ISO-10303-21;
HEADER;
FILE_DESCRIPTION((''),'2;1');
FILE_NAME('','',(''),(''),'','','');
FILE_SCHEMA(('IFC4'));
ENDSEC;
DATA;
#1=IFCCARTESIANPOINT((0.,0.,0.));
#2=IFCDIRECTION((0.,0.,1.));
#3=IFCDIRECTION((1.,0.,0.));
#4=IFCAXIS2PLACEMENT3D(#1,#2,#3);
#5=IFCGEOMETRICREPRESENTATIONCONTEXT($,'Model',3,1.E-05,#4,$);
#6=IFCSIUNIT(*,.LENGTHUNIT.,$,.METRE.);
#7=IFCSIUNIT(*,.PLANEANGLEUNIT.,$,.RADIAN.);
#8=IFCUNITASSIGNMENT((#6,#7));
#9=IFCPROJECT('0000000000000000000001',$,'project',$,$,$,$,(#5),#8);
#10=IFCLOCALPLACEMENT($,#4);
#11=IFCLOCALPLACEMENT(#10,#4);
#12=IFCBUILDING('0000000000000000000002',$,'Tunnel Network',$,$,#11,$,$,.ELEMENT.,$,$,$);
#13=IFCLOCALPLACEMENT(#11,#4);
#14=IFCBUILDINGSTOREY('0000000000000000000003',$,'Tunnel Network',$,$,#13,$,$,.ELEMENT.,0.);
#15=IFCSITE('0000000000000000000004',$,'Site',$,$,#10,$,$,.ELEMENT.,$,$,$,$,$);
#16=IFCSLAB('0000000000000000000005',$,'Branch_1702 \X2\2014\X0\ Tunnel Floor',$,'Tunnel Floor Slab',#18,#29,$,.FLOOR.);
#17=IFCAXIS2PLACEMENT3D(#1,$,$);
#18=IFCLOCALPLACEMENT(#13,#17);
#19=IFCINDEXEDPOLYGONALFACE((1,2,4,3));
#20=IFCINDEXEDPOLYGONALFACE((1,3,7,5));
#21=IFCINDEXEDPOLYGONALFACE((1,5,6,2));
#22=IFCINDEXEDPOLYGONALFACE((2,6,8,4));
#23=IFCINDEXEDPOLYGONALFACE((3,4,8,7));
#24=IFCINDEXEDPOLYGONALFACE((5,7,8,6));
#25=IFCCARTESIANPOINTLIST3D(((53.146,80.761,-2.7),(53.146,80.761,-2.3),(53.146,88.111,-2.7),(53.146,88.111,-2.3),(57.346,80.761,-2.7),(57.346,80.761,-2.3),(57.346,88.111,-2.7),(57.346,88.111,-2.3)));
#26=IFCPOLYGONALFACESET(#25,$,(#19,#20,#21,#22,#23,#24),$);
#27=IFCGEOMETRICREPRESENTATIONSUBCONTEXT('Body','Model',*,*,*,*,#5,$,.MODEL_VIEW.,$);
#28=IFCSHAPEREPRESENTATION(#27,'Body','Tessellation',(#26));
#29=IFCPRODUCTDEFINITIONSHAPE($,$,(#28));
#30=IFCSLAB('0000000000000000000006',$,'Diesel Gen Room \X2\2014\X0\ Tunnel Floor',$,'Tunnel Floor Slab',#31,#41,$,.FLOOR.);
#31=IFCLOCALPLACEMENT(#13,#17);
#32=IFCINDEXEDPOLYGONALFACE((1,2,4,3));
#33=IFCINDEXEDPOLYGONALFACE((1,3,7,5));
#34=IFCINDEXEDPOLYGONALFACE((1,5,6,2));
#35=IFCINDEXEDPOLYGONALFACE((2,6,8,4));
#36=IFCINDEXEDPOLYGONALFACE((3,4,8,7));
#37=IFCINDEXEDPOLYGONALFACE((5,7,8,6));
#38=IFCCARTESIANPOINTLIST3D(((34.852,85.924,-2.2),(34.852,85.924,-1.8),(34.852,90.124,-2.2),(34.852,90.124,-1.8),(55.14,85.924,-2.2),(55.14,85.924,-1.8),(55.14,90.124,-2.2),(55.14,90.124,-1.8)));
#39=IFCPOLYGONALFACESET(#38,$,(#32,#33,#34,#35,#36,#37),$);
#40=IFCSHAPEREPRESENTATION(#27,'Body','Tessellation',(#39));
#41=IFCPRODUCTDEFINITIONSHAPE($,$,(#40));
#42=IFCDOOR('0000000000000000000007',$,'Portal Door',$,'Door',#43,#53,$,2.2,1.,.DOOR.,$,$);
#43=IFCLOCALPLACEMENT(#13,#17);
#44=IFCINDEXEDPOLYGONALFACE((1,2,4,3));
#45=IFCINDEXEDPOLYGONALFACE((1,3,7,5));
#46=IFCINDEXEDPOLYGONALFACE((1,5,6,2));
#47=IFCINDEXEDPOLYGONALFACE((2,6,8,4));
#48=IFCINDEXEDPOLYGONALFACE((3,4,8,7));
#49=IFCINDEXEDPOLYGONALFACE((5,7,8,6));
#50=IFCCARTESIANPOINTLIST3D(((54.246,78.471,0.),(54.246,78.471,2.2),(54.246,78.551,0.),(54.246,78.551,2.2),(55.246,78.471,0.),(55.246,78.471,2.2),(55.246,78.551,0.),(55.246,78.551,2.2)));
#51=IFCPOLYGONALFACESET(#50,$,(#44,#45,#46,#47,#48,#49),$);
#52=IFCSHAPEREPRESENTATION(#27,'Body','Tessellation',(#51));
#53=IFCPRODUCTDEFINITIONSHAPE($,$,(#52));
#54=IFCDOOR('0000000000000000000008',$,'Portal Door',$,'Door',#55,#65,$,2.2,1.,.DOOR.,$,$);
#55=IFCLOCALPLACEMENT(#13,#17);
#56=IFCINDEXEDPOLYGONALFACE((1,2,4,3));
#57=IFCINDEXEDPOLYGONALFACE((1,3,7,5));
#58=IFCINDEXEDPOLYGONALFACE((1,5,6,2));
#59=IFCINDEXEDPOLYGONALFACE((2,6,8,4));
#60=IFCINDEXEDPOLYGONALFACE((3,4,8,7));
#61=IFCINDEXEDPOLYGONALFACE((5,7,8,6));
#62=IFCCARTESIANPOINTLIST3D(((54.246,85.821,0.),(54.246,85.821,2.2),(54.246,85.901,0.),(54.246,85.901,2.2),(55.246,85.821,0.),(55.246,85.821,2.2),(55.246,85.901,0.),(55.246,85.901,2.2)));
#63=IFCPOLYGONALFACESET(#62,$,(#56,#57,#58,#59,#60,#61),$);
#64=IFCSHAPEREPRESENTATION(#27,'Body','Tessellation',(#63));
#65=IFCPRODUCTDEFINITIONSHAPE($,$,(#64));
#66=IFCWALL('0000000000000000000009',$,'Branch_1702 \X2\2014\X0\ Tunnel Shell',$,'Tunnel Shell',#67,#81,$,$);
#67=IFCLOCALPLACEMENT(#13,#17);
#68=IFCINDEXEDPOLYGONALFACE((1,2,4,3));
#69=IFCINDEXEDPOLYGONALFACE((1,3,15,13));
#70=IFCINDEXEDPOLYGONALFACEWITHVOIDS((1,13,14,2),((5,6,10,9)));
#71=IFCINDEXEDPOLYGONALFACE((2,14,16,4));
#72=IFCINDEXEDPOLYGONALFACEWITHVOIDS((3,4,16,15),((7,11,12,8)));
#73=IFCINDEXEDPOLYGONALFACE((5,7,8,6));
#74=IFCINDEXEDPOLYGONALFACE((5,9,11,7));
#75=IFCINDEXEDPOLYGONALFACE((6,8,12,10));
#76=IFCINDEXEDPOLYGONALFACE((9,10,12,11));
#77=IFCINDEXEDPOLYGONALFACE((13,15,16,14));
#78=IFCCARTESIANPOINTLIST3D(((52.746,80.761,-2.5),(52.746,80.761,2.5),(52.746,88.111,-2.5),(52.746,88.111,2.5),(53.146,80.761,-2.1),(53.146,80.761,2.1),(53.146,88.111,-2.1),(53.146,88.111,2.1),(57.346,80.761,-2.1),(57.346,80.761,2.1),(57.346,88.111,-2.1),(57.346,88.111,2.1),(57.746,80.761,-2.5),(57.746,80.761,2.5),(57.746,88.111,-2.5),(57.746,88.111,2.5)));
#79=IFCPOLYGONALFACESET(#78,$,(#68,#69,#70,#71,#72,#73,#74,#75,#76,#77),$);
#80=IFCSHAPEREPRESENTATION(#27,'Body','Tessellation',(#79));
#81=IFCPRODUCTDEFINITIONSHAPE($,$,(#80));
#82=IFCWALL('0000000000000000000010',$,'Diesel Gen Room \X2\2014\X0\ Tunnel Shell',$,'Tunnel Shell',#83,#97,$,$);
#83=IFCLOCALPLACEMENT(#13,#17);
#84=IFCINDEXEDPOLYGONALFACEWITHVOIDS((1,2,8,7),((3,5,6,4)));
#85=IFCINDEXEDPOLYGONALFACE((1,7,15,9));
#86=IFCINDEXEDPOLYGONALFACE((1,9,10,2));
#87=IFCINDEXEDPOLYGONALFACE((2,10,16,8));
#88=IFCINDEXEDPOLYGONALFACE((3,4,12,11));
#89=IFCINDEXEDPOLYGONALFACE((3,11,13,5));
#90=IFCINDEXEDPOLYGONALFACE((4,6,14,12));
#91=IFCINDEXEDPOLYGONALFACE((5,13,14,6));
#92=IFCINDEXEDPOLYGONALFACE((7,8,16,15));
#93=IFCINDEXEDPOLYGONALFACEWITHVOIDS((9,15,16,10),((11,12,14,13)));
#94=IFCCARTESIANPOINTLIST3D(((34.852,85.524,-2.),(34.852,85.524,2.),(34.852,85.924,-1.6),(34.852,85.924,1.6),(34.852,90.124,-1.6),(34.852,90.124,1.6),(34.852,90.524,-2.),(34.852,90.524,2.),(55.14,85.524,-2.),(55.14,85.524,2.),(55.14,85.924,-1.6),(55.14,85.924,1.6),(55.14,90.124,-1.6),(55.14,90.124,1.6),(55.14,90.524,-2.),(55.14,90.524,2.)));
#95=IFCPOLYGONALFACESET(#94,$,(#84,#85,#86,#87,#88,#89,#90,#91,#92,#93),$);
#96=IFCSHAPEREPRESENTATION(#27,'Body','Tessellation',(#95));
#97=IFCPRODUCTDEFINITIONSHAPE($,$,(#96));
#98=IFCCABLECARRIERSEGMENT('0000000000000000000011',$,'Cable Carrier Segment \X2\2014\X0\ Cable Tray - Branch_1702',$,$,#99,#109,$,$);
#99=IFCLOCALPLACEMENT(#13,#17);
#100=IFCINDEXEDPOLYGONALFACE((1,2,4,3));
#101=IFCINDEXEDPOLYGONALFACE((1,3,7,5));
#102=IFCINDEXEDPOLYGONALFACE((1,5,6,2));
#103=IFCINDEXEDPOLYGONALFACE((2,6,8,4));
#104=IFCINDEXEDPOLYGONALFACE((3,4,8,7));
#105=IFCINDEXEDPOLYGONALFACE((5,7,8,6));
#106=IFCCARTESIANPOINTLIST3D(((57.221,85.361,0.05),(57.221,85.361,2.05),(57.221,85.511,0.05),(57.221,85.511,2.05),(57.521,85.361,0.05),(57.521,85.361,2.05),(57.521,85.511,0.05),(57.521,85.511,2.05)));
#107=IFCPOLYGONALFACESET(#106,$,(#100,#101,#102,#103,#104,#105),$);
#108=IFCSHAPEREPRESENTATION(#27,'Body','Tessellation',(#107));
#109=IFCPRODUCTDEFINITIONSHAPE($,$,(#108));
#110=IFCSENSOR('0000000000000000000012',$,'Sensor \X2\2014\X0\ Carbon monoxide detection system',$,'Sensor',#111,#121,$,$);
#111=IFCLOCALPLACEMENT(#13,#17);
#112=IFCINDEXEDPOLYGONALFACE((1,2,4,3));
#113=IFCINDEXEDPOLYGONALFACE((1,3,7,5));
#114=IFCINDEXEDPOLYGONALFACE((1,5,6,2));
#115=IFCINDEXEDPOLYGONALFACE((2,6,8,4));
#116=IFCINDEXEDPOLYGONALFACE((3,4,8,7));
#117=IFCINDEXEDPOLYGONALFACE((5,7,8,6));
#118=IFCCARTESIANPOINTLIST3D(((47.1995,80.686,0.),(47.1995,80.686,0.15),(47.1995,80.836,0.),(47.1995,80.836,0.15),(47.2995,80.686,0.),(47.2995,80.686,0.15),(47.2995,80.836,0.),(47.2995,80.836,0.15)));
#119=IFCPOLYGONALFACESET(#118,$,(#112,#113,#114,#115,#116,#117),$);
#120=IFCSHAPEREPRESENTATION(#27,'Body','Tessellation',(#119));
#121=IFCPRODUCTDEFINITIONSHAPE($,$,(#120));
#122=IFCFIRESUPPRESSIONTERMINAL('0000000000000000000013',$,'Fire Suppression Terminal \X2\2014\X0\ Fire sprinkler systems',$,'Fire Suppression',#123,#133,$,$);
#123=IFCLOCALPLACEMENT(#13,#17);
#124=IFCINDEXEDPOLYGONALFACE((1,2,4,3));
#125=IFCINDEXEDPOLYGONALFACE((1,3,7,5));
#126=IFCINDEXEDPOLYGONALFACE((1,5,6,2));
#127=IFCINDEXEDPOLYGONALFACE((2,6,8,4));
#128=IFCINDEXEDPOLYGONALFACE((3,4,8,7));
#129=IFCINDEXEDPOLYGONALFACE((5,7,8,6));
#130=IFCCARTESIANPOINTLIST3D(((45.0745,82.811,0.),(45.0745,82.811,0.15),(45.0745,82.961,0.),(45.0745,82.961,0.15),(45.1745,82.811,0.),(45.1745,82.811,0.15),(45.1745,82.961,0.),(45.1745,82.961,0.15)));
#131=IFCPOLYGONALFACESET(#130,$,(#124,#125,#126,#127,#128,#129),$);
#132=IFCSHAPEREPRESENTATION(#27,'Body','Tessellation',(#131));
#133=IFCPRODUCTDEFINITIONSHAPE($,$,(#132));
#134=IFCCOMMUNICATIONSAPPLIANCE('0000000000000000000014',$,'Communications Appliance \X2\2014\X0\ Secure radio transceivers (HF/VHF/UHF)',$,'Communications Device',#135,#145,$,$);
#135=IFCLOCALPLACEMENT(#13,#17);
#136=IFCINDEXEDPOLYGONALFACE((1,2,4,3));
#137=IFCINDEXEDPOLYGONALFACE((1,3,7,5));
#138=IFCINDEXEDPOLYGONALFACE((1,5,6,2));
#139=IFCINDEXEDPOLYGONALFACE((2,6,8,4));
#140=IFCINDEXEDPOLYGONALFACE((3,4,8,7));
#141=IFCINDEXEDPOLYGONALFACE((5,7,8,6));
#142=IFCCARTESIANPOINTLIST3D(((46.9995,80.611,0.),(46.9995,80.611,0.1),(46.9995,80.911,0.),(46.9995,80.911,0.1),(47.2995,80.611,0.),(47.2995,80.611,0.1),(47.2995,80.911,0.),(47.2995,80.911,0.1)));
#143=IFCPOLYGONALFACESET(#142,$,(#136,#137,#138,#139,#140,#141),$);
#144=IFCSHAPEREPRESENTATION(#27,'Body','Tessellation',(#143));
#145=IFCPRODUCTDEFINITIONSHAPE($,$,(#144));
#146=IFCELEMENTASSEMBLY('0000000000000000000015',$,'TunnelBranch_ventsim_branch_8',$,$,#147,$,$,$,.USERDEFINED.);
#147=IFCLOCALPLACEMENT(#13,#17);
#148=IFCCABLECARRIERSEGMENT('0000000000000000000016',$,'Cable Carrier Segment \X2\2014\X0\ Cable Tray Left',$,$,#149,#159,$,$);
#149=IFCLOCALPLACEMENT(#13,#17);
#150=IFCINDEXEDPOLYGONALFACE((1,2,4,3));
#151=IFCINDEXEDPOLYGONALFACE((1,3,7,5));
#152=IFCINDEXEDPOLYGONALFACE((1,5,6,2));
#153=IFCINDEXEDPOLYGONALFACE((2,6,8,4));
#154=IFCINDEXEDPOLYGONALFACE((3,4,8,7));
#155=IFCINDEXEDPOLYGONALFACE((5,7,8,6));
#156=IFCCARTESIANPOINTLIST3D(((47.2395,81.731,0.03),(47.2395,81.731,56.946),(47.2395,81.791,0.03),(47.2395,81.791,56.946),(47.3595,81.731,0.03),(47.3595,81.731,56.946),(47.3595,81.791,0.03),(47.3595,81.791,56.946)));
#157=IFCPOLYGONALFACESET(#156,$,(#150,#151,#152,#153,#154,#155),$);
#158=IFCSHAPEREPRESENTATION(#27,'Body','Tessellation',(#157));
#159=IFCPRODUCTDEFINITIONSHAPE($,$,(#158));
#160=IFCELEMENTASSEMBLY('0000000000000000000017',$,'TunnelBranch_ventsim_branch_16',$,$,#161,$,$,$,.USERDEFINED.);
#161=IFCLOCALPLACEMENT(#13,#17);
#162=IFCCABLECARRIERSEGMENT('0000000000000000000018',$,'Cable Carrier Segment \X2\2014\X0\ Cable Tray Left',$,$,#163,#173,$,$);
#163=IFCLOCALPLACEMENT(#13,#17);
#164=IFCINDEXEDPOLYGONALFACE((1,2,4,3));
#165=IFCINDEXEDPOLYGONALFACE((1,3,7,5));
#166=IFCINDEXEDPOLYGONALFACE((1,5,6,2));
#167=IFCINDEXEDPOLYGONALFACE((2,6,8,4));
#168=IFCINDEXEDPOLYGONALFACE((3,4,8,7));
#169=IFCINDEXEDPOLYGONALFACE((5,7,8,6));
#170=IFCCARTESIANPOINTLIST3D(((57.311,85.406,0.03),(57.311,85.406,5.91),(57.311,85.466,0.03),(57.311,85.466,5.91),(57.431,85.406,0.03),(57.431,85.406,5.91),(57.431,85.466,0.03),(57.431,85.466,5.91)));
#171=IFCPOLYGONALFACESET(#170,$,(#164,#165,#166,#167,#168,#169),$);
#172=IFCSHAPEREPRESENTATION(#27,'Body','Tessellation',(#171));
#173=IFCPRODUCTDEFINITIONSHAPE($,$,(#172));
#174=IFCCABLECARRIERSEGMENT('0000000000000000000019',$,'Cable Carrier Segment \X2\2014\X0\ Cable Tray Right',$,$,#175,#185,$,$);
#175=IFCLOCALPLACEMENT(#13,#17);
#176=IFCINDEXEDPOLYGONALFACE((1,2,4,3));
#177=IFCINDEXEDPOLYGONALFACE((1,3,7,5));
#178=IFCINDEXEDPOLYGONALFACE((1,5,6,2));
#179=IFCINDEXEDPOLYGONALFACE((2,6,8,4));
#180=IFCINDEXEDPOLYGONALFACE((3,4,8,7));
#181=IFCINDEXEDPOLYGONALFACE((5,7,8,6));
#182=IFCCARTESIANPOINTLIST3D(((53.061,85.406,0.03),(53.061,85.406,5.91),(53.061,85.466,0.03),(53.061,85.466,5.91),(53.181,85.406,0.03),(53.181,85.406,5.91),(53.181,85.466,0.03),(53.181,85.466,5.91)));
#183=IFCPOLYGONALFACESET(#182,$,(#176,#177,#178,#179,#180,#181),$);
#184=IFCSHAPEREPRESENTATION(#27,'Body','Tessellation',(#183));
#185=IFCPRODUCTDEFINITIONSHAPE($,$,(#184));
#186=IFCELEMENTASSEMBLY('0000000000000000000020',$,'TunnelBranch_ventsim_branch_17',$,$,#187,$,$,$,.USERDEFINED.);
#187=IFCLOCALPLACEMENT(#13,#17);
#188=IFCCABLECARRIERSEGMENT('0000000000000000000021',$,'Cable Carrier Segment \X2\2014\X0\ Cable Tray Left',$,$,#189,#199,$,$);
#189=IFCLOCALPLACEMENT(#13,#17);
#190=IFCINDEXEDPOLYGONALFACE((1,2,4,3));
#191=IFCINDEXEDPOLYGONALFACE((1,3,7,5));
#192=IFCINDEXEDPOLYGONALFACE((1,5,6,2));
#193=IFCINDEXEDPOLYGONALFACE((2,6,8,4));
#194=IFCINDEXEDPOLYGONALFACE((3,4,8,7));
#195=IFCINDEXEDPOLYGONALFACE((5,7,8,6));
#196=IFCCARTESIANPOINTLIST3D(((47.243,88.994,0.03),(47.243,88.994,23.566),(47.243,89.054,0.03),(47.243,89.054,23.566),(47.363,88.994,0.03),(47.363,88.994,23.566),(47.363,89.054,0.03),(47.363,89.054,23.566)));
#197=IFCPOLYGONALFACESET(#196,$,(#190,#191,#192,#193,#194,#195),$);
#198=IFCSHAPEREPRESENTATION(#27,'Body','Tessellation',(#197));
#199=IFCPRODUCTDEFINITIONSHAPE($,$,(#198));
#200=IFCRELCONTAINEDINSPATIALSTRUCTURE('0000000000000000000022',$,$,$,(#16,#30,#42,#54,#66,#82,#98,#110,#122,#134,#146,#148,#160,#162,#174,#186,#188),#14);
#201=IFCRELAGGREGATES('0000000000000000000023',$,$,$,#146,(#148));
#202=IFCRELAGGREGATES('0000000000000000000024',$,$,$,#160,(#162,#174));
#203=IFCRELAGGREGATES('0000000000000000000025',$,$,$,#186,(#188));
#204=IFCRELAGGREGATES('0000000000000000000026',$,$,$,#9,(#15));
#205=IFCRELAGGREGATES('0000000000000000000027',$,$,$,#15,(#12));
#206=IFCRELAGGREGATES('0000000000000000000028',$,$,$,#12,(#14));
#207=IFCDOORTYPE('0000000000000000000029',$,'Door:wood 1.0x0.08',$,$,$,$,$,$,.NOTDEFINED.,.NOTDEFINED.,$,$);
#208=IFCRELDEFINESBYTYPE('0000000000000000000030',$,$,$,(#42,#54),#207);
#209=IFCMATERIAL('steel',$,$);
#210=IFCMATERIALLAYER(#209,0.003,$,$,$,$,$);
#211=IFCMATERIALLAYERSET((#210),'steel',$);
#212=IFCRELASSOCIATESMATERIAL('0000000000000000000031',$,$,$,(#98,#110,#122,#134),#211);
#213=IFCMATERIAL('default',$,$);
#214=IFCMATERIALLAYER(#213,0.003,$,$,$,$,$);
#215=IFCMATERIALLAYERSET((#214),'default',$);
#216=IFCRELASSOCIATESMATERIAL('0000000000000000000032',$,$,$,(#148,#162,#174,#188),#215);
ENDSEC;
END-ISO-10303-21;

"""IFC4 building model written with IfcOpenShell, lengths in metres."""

from ifc_helpers import new_model, si_unit, frame, origin_with_axes, origin_2d_with_axis, place, context, subcontext, project, spatial, rectangle, hollow_rectangle, extrude, material, layer, layer_set, layer_usage, type_object, element, aggregate, save


model = new_model("IFC4")

# Units and contexts
model_context = context("Model", 3, precision=1e-05, world=origin_with_axes())
body_context = subcontext(model_context, "Body", "Model", "MODEL_VIEW")
ifc_project = project(units=[si_unit("LENGTHUNIT", "METRE"), si_unit("PLANEANGLEUNIT", "RADIAN")], contexts=[model_context])

# Site, building, storey
site_placement = place(None, origin_with_axes())
site = spatial("IfcSite", under=ifc_project, at=site_placement, Name="Site", CompositionType="ELEMENT")
building_placement = place(site_placement, origin_with_axes())
building = spatial("IfcBuilding", under=site, at=building_placement, Name="Tunnel Network", CompositionType="ELEMENT")
storey_placement = place(building_placement, origin_with_axes())
storey = spatial("IfcBuildingStorey", under=building, at=storey_placement, Name="Tunnel Network", CompositionType="ELEMENT", Elevation=0.0)

# Slabs
placement_1 = place(storey_placement, frame((55.246, 80.761, 0.0), z_axis=(0.0, 0.0, 1.0), x_axis=(0.0, 1.0, 0.0)))
element("IfcSlab", 1, at=placement_1, inside=storey, Name="Branch_1702 — Tunnel Floor", ObjectType="Tunnel Floor Slab", PredefinedType="FLOOR", context=body_context, shape_type="SweptSolid", body=[
    extrude(rectangle(XDim=0.4, YDim=4.2, at=origin_2d_with_axis()), frame((0.0, 0.0, -2.5), z_axis=(1.0, 0.0, 0.0), x_axis=(0.0, 0.0, 1.0)), (0.0, 0.0, 1.0), 7.35),
])
placement_2 = place(storey_placement, frame((55.14, 88.024, 0.0), z_axis=(0.0, 0.0, 1.0), x_axis=(-1.0, 0.0, 0.0)))
element("IfcSlab", 2, at=placement_2, inside=storey, Name="Diesel Gen Room — Tunnel Floor", ObjectType="Tunnel Floor Slab", PredefinedType="FLOOR", context=body_context, shape_type="SweptSolid", body=[
    extrude(rectangle(XDim=0.4, YDim=4.2, at=origin_2d_with_axis()), frame((0.0, 0.0, -2.0), z_axis=(1.0, 0.0, 0.0), x_axis=(0.0, 0.0, 1.0)), (0.0, 0.0, 1.0), 20.288),
])

# Doors
door_type = type_object("IfcDoorType", Name="Door:wood 1.0x0.08")
for number, where, z_axis, x_axis, name in (
    (3, (54.746, 78.511, 0.0), (0.0, 0.0, 1.0), (1.0, 0.0, 0.0), "Portal Door"),
    (4, (54.746, 85.861, 0.0), (0.0, 0.0, 1.0), (1.0, 0.0, 0.0), "Portal Door"),
):
    element("IfcDoor", number, at=place(storey_placement, frame(where, z_axis=z_axis, x_axis=x_axis)), inside=storey, type_object=door_type, Name=name, ObjectType="Door", OverallHeight=2.2, OverallWidth=1.0, PredefinedType="DOOR", context=body_context, shape_type="SweptSolid", body=[
        extrude(rectangle(XDim=1.0, YDim=0.08, at=origin_2d_with_axis()), origin_with_axes(), (0.0, 0.0, 1.0), 2.2),
    ])

# Walls
element("IfcWall", 5, at=placement_1, inside=storey, Name="Branch_1702 — Tunnel Shell", ObjectType="Tunnel Shell", context=body_context, shape_type="SweptSolid", body=[
    extrude(hollow_rectangle(XDim=5.0, YDim=5.0, WallThickness=0.4, at=origin_2d_with_axis()), frame((0.0, 0.0, 0.0), z_axis=(1.0, 0.0, 0.0), x_axis=(0.0, 0.0, 1.0)), (0.0, 0.0, 1.0), 7.35),
])
element("IfcWall", 6, at=placement_2, inside=storey, Name="Diesel Gen Room — Tunnel Shell", ObjectType="Tunnel Shell", context=body_context, shape_type="SweptSolid", body=[
    extrude(hollow_rectangle(XDim=4.0, YDim=5.0, WallThickness=0.4, at=origin_2d_with_axis()), frame((0.0, 0.0, 0.0), z_axis=(1.0, 0.0, 0.0), x_axis=(0.0, 0.0, 1.0)), (0.0, 0.0, 1.0), 20.288),
])

# Cable carrier segment
ifc_material_1 = material(Name="steel")
ifc_layer_1 = layer(ifc_material_1, 0.003)
ifc_layer_set_1 = layer_set([ifc_layer_1], Name="steel")
ifc_layer_usage_1 = layer_usage(ifc_layer_set_1, "AXIS2", "POSITIVE", 0.0)
cable_carrier_segment_1_placement = place(storey_placement, frame((57.371, 85.436, 0.05), z_axis=(0.0, 0.0, 1.0), x_axis=(-1.0, 0.0, 0.0)))
element("IfcCableCarrierSegment", 7, at=cable_carrier_segment_1_placement, inside=storey, material=ifc_layer_usage_1, Name="Cable Carrier Segment — Cable Tray - Branch_1702", context=body_context, shape_type="SweptSolid", body=[
    extrude(rectangle(XDim=0.3, YDim=0.15, at=origin_2d_with_axis()), origin_with_axes(), (0.0, 0.0, 1.0), 2.0),
])

# Sensor
ifc_layer_usage_2 = layer_usage(ifc_layer_set_1, "AXIS2", "POSITIVE", 0.0)
sensor_placement = place(storey_placement, frame((47.2995, 80.761, 0.075), z_axis=(-1.0, 0.0, 0.0), x_axis=(0.0, 1.0, 0.0)))
element("IfcSensor", 8, at=sensor_placement, inside=storey, material=ifc_layer_usage_2, Name="Sensor — Carbon monoxide detection system", ObjectType="Sensor", context=body_context, shape_type="SweptSolid", body=[
    extrude(rectangle(XDim=0.15, YDim=0.15, at=origin_2d_with_axis()), origin_with_axes(), (0.0, 0.0, 1.0), 0.1),
])

# Fire suppression terminal
ifc_layer_usage_3 = layer_usage(ifc_layer_set_1, "AXIS2", "POSITIVE", 0.0)
fire_suppression_terminal_placement = place(storey_placement, frame((45.1745, 82.886, 0.075), z_axis=(-1.0, 0.0, 0.0), x_axis=(0.0, 1.0, 0.0)))
element("IfcFireSuppressionTerminal", 9, at=fire_suppression_terminal_placement, inside=storey, material=ifc_layer_usage_3, Name="Fire Suppression Terminal — Fire sprinkler systems", ObjectType="Fire Suppression", context=body_context, shape_type="SweptSolid", body=[
    extrude(rectangle(XDim=0.15, YDim=0.15, at=origin_2d_with_axis()), origin_with_axes(), (0.0, 0.0, 1.0), 0.1),
])

# Communications appliance
ifc_layer_usage_4 = layer_usage(ifc_layer_set_1, "AXIS2", "POSITIVE", 0.0)
communications_appliance_1_placement = place(storey_placement, frame((47.2995, 80.761, 0.05), z_axis=(-1.0, 0.0, 0.0), x_axis=(0.0, 1.0, 0.0)))
element("IfcCommunicationsAppliance", 10, at=communications_appliance_1_placement, inside=storey, material=ifc_layer_usage_4, Name="Communications Appliance — Secure radio transceivers (HF/VHF/UHF)", ObjectType="Communications Device", context=body_context, shape_type="SweptSolid", body=[
    extrude(rectangle(XDim=0.3, YDim=0.1, at=origin_2d_with_axis()), origin_with_axes(), (0.0, 0.0, 1.0), 0.3),
])

# Element assembly, cable carrier segment
assembly_1_placement = place(storey_placement, frame((47.6745, 80.761, 43.5572), z_axis=(0.0, 1.0, 0.0), x_axis=(-1.0, 0.0, 0.0)))
assembly_1 = element("IfcElementAssembly", 11, at=assembly_1_placement, inside=storey, Name="TunnelBranch_ventsim_branch_8", PredefinedType="USERDEFINED")
ifc_material_2 = material(Name="default")
ifc_layer_2 = layer(ifc_material_2, 0.003)
ifc_layer_set_2 = layer_set([ifc_layer_2], Name="default")
ifc_layer_usage_5 = layer_usage(ifc_layer_set_2, "AXIS2", "POSITIVE", 0.0)
cable_carrier_segment_2_placement = place(storey_placement, frame((47.2995, 81.761, 0.03), z_axis=(0.0, 0.0, 1.0), x_axis=(-1.0, 0.0, 0.0)))
cable_carrier_segment_2 = element("IfcCableCarrierSegment", 12, at=cable_carrier_segment_2_placement, inside=storey, material=ifc_layer_usage_5, Name="Cable Carrier Segment — Cable Tray Left", context=body_context, shape_type="SweptSolid", body=[
    extrude(rectangle(XDim=0.12, YDim=0.06, at=origin_2d_with_axis()), origin_with_axes(), (0.0, 0.0, 1.0), 56.916),
])
aggregate(assembly_1, [cable_carrier_segment_2])

# Element assembly, cable carrier segments
assembly_2_placement = place(storey_placement, frame((55.246, 86.561, 0.735), z_axis=(0.0, 0.0, 1.0), x_axis=(-1.0, 0.0, 0.0)))
assembly_2 = element("IfcElementAssembly", 13, at=assembly_2_placement, inside=storey, Name="TunnelBranch_ventsim_branch_16", PredefinedType="USERDEFINED")
ifc_layer_usage_6 = layer_usage(ifc_layer_set_2, "AXIS2", "POSITIVE", 0.0)
cable_carrier_segment_3_placement = place(storey_placement, frame((57.371, 85.436, 0.03), z_axis=(0.0, 0.0, 1.0), x_axis=(-1.0, 0.0, 0.0)))
cable_carrier_segment_3 = element("IfcCableCarrierSegment", 14, at=cable_carrier_segment_3_placement, inside=storey, material=ifc_layer_usage_6, Name="Cable Carrier Segment — Cable Tray Left", context=body_context, shape_type="SweptSolid", body=[
    extrude(rectangle(XDim=0.12, YDim=0.06, at=origin_2d_with_axis()), origin_with_axes(), (0.0, 0.0, 1.0), 5.88),
])
ifc_layer_usage_7 = layer_usage(ifc_layer_set_2, "AXIS2", "POSITIVE", 0.0)
cable_carrier_segment_4_placement = place(storey_placement, frame((53.121, 85.436, 0.03), z_axis=(0.0, 0.0, 1.0), x_axis=(-1.0, 0.0, 0.0)))
cable_carrier_segment_4 = element("IfcCableCarrierSegment", 15, at=cable_carrier_segment_4_placement, inside=storey, material=ifc_layer_usage_7, Name="Cable Carrier Segment — Cable Tray Right", context=body_context, shape_type="SweptSolid", body=[
    extrude(rectangle(XDim=0.12, YDim=0.06, at=origin_2d_with_axis()), origin_with_axes(), (0.0, 0.0, 1.0), 5.88),
])
aggregate(assembly_2, [cable_carrier_segment_3, cable_carrier_segment_4])

# Element assembly, cable carrier segment
assembly_3_placement = place(storey_placement, frame((45.178, 90.149, 1.25), z_axis=(0.0, 1.0, 0.0), x_axis=(-1.0, 0.0, 0.0)))
assembly_3 = element("IfcElementAssembly", 16, at=assembly_3_placement, inside=storey, Name="TunnelBranch_ventsim_branch_17", PredefinedType="USERDEFINED")
ifc_layer_usage_8 = layer_usage(ifc_layer_set_2, "AXIS2", "POSITIVE", 0.0)
cable_carrier_segment_5_placement = place(storey_placement, frame((47.303, 89.024, 0.03), z_axis=(0.0, 0.0, 1.0), x_axis=(-1.0, 0.0, 0.0)))
cable_carrier_segment_5 = element("IfcCableCarrierSegment", 17, at=cable_carrier_segment_5_placement, inside=storey, material=ifc_layer_usage_8, Name="Cable Carrier Segment — Cable Tray Left", context=body_context, shape_type="SweptSolid", body=[
    extrude(rectangle(XDim=0.12, YDim=0.06, at=origin_2d_with_axis()), origin_with_axes(), (0.0, 0.0, 1.0), 23.536),
])
aggregate(assembly_3, [cable_carrier_segment_5])

save(model, "model.ifc")
